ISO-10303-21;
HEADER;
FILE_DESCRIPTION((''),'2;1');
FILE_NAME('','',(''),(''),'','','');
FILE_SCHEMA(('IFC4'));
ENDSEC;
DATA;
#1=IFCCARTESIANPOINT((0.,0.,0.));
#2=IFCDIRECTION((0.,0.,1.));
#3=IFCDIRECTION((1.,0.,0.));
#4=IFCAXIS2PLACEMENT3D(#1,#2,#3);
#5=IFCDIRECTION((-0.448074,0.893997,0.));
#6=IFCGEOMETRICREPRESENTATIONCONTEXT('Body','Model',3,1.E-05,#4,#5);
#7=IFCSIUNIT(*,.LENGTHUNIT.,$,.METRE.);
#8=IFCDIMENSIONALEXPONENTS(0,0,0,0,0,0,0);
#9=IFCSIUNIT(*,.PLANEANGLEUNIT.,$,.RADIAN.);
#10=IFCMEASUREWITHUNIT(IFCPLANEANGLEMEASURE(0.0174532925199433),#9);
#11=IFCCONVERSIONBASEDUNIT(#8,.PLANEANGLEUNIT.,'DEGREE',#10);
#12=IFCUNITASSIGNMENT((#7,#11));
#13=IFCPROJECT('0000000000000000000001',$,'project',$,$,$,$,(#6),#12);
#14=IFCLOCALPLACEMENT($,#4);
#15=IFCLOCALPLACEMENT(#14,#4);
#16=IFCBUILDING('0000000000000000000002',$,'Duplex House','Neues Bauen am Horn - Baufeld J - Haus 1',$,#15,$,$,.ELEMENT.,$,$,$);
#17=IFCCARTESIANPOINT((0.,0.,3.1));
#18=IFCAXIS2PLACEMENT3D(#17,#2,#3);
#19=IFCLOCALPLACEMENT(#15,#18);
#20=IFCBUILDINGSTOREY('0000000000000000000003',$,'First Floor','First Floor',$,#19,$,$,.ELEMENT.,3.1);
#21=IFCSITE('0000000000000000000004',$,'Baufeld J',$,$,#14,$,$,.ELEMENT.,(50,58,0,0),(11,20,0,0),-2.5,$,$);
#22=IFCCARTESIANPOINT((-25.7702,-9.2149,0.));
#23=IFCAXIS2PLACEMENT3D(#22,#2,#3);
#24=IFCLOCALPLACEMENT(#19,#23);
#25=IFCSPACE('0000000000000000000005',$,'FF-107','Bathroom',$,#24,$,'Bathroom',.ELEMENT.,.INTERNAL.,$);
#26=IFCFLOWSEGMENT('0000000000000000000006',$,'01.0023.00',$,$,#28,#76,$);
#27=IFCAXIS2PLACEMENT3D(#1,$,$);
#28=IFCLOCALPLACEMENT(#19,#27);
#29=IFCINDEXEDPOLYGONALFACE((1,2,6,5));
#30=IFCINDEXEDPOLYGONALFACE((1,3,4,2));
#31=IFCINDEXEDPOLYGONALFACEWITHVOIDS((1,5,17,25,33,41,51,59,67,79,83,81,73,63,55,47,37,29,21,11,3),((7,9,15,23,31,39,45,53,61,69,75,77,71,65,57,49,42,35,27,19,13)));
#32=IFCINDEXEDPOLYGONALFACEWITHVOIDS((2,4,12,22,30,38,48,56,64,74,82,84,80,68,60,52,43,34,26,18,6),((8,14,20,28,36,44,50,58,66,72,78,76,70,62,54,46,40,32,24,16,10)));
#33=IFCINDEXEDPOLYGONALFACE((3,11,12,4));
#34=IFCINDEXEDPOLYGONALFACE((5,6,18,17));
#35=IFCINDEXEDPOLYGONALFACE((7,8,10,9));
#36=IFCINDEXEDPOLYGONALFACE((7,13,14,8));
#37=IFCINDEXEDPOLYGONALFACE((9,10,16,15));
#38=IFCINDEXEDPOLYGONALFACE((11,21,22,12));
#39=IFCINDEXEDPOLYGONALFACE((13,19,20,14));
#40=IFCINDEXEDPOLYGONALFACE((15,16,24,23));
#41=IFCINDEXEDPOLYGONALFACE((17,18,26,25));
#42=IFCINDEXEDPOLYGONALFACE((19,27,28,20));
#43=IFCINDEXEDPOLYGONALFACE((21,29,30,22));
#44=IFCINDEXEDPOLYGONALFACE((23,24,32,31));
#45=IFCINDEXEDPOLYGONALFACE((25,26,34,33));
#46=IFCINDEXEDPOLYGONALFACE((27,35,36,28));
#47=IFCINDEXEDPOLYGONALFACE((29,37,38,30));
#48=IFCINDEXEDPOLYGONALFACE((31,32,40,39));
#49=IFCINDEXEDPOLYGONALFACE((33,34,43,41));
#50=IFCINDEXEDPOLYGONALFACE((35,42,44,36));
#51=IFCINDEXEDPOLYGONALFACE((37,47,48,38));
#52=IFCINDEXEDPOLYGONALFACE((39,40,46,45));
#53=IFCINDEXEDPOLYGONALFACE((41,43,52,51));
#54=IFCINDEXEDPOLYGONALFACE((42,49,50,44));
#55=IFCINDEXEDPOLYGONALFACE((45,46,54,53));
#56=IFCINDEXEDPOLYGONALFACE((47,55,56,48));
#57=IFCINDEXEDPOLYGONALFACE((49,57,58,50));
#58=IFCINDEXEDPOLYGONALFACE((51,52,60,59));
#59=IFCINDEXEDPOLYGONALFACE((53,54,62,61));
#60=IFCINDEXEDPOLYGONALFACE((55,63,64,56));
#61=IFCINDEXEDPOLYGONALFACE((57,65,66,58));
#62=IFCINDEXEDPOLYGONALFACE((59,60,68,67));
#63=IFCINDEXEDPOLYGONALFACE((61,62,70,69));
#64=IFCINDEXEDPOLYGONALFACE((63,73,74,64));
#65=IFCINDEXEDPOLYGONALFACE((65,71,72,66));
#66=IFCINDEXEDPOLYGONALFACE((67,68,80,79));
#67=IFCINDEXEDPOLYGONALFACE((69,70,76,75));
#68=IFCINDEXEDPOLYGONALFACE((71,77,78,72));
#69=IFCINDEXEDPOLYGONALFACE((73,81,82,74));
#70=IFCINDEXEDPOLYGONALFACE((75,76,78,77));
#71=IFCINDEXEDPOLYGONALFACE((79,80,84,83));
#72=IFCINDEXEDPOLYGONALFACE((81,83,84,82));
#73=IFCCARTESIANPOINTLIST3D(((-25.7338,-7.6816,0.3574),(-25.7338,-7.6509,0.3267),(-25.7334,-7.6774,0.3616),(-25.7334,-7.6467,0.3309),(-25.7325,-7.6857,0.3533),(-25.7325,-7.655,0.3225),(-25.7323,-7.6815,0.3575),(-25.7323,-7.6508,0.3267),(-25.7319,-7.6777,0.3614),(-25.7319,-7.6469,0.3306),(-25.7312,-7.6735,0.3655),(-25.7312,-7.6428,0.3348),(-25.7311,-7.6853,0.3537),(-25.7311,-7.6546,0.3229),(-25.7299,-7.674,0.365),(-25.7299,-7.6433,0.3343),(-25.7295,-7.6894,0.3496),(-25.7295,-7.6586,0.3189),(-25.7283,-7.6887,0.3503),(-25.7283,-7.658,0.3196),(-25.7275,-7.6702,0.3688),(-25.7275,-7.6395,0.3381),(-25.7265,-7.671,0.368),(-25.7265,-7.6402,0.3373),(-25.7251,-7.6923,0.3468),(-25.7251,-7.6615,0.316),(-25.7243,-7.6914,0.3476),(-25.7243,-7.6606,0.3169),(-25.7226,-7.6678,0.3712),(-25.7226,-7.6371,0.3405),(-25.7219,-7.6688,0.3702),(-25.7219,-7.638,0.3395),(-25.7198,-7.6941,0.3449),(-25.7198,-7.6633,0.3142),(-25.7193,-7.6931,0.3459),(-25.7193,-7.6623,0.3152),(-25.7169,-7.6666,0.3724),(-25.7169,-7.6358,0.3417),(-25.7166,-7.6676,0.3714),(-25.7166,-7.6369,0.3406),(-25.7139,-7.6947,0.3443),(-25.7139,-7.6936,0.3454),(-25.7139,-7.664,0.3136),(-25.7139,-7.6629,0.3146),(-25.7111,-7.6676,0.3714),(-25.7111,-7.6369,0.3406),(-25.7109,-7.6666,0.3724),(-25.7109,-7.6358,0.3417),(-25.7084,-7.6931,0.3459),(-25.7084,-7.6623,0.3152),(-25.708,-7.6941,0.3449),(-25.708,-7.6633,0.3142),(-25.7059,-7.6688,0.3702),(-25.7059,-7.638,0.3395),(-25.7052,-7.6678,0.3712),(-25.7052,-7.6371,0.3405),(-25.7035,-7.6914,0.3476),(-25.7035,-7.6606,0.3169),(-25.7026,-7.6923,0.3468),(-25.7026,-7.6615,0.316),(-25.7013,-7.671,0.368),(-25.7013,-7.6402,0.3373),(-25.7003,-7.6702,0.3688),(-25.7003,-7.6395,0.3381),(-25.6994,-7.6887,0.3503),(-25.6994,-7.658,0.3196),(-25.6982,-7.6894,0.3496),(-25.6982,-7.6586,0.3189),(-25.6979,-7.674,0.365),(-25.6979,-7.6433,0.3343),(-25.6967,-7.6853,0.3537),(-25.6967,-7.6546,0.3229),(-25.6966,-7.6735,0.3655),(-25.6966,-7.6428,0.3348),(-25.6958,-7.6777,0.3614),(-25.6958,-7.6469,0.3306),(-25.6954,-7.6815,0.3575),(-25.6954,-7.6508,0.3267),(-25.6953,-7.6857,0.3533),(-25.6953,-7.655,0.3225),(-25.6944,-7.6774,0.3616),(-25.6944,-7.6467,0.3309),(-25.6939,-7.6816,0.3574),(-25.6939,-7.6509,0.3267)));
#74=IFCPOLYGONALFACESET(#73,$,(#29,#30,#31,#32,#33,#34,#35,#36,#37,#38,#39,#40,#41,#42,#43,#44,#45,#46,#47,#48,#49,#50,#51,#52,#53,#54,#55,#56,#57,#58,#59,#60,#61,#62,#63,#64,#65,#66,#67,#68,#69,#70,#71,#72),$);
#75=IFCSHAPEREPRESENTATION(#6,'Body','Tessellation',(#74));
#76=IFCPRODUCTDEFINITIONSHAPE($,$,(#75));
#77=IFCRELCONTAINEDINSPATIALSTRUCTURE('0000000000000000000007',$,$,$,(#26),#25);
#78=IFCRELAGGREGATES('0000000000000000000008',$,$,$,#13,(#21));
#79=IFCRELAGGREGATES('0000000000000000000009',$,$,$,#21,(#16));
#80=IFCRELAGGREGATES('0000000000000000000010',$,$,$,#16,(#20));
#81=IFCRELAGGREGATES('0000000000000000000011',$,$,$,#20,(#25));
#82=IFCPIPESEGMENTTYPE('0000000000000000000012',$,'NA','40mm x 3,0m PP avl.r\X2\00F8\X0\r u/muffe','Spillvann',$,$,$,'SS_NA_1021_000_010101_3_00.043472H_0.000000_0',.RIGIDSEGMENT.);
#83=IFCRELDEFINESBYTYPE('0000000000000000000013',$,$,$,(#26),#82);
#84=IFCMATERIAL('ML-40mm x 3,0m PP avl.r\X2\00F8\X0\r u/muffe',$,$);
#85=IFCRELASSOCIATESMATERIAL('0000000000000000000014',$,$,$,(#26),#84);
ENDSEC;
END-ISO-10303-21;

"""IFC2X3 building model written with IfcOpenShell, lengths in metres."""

from ifc_helpers import new_model, entity, si_unit, converted_unit, direction, frame, origin_with_axes, origin_2d_with_axis, place, context, project, spatial, hollow_circle, extrude, material, type_object, element, save


model = new_model("IFC2X3")

# Units and contexts
model_context = context("Model", 3, precision=1e-05, world=origin_with_axes(), true_north=direction((-0.448074, 0.893997, 0.0)), identifier="Body")
ifc_project = project(units=[si_unit("LENGTHUNIT", "METRE"), converted_unit("PLANEANGLEUNIT", "DEGREE", entity("IfcPlaneAngleMeasure", 0.0174532925199433), si_unit("PLANEANGLEUNIT", "RADIAN"), dimensions=[0, 0, 0, 0, 0, 0, 0])], contexts=[model_context])

# Site, building, storey, space
site_placement = place(None, origin_with_axes())
site = spatial("IfcSite", under=ifc_project, at=site_placement, Name="Baufeld J", CompositionType="ELEMENT", RefLatitude=(50, 58, 0, 0), RefLongitude=(11, 20, 0, 0), RefElevation=-2.5)
building_placement = place(site_placement, origin_with_axes())
building = spatial("IfcBuilding", under=site, at=building_placement, Name="Duplex House", Description="Neues Bauen am Horn - Baufeld J - Haus 1", CompositionType="ELEMENT")
storey_placement = place(building_placement, frame((0.0, 0.0, 3.1), z_axis=(0.0, 0.0, 1.0), x_axis=(1.0, 0.0, 0.0)))
storey = spatial("IfcBuildingStorey", under=building, at=storey_placement, Name="First Floor", Description="First Floor", CompositionType="ELEMENT", Elevation=3.1)
space_1_placement = place(storey_placement, frame((-25.7702, -9.2149, 0.0), z_axis=(0.0, 0.0, 1.0), x_axis=(1.0, 0.0, 0.0)))
space_1 = spatial("IfcSpace", under=storey, at=space_1_placement, Name="FF-107", Description="Bathroom", LongName="Bathroom", CompositionType="ELEMENT", InteriorOrExteriorSpace="INTERNAL")

# Flow segment
ifc_material_1 = material(Name="ML-40mm x 3,0m PP avl.rør u/muffe")
pipe_segment_type_1 = type_object("IfcPipeSegmentType", Name="NA", Description="40mm x 3,0m PP avl.rør u/muffe", ApplicableOccurrence="Spillvann", ElementType="SS_NA_1021_000_010101_3_00.043472H_0.000000_0", PredefinedType="RIGIDSEGMENT")
flow_segment_1_placement = place(space_1_placement, frame((0.0563, 1.5651, 0.3277), z_axis=(0.0, 0.707107, 0.707107), x_axis=(0.0, -0.707107, 0.707107)))
element("IfcFlowSegment", 1, at=flow_segment_1_placement, inside=space_1, type_object=pipe_segment_type_1, material=ifc_material_1, Name="01.0023.00", context=model_context, shape_type="SweptSolid", body=[
    extrude(hollow_circle(Radius=0.02, WallThickness=0.0015, at=origin_2d_with_axis()), frame((0.0, 0.0, 0.0), z_axis=(1.0, 0.0, 0.0), x_axis=(0.0, 0.0, -1.0)), (0.0, 0.0, 1.0), 0.0435),
])

save(model, "model.ifc")
